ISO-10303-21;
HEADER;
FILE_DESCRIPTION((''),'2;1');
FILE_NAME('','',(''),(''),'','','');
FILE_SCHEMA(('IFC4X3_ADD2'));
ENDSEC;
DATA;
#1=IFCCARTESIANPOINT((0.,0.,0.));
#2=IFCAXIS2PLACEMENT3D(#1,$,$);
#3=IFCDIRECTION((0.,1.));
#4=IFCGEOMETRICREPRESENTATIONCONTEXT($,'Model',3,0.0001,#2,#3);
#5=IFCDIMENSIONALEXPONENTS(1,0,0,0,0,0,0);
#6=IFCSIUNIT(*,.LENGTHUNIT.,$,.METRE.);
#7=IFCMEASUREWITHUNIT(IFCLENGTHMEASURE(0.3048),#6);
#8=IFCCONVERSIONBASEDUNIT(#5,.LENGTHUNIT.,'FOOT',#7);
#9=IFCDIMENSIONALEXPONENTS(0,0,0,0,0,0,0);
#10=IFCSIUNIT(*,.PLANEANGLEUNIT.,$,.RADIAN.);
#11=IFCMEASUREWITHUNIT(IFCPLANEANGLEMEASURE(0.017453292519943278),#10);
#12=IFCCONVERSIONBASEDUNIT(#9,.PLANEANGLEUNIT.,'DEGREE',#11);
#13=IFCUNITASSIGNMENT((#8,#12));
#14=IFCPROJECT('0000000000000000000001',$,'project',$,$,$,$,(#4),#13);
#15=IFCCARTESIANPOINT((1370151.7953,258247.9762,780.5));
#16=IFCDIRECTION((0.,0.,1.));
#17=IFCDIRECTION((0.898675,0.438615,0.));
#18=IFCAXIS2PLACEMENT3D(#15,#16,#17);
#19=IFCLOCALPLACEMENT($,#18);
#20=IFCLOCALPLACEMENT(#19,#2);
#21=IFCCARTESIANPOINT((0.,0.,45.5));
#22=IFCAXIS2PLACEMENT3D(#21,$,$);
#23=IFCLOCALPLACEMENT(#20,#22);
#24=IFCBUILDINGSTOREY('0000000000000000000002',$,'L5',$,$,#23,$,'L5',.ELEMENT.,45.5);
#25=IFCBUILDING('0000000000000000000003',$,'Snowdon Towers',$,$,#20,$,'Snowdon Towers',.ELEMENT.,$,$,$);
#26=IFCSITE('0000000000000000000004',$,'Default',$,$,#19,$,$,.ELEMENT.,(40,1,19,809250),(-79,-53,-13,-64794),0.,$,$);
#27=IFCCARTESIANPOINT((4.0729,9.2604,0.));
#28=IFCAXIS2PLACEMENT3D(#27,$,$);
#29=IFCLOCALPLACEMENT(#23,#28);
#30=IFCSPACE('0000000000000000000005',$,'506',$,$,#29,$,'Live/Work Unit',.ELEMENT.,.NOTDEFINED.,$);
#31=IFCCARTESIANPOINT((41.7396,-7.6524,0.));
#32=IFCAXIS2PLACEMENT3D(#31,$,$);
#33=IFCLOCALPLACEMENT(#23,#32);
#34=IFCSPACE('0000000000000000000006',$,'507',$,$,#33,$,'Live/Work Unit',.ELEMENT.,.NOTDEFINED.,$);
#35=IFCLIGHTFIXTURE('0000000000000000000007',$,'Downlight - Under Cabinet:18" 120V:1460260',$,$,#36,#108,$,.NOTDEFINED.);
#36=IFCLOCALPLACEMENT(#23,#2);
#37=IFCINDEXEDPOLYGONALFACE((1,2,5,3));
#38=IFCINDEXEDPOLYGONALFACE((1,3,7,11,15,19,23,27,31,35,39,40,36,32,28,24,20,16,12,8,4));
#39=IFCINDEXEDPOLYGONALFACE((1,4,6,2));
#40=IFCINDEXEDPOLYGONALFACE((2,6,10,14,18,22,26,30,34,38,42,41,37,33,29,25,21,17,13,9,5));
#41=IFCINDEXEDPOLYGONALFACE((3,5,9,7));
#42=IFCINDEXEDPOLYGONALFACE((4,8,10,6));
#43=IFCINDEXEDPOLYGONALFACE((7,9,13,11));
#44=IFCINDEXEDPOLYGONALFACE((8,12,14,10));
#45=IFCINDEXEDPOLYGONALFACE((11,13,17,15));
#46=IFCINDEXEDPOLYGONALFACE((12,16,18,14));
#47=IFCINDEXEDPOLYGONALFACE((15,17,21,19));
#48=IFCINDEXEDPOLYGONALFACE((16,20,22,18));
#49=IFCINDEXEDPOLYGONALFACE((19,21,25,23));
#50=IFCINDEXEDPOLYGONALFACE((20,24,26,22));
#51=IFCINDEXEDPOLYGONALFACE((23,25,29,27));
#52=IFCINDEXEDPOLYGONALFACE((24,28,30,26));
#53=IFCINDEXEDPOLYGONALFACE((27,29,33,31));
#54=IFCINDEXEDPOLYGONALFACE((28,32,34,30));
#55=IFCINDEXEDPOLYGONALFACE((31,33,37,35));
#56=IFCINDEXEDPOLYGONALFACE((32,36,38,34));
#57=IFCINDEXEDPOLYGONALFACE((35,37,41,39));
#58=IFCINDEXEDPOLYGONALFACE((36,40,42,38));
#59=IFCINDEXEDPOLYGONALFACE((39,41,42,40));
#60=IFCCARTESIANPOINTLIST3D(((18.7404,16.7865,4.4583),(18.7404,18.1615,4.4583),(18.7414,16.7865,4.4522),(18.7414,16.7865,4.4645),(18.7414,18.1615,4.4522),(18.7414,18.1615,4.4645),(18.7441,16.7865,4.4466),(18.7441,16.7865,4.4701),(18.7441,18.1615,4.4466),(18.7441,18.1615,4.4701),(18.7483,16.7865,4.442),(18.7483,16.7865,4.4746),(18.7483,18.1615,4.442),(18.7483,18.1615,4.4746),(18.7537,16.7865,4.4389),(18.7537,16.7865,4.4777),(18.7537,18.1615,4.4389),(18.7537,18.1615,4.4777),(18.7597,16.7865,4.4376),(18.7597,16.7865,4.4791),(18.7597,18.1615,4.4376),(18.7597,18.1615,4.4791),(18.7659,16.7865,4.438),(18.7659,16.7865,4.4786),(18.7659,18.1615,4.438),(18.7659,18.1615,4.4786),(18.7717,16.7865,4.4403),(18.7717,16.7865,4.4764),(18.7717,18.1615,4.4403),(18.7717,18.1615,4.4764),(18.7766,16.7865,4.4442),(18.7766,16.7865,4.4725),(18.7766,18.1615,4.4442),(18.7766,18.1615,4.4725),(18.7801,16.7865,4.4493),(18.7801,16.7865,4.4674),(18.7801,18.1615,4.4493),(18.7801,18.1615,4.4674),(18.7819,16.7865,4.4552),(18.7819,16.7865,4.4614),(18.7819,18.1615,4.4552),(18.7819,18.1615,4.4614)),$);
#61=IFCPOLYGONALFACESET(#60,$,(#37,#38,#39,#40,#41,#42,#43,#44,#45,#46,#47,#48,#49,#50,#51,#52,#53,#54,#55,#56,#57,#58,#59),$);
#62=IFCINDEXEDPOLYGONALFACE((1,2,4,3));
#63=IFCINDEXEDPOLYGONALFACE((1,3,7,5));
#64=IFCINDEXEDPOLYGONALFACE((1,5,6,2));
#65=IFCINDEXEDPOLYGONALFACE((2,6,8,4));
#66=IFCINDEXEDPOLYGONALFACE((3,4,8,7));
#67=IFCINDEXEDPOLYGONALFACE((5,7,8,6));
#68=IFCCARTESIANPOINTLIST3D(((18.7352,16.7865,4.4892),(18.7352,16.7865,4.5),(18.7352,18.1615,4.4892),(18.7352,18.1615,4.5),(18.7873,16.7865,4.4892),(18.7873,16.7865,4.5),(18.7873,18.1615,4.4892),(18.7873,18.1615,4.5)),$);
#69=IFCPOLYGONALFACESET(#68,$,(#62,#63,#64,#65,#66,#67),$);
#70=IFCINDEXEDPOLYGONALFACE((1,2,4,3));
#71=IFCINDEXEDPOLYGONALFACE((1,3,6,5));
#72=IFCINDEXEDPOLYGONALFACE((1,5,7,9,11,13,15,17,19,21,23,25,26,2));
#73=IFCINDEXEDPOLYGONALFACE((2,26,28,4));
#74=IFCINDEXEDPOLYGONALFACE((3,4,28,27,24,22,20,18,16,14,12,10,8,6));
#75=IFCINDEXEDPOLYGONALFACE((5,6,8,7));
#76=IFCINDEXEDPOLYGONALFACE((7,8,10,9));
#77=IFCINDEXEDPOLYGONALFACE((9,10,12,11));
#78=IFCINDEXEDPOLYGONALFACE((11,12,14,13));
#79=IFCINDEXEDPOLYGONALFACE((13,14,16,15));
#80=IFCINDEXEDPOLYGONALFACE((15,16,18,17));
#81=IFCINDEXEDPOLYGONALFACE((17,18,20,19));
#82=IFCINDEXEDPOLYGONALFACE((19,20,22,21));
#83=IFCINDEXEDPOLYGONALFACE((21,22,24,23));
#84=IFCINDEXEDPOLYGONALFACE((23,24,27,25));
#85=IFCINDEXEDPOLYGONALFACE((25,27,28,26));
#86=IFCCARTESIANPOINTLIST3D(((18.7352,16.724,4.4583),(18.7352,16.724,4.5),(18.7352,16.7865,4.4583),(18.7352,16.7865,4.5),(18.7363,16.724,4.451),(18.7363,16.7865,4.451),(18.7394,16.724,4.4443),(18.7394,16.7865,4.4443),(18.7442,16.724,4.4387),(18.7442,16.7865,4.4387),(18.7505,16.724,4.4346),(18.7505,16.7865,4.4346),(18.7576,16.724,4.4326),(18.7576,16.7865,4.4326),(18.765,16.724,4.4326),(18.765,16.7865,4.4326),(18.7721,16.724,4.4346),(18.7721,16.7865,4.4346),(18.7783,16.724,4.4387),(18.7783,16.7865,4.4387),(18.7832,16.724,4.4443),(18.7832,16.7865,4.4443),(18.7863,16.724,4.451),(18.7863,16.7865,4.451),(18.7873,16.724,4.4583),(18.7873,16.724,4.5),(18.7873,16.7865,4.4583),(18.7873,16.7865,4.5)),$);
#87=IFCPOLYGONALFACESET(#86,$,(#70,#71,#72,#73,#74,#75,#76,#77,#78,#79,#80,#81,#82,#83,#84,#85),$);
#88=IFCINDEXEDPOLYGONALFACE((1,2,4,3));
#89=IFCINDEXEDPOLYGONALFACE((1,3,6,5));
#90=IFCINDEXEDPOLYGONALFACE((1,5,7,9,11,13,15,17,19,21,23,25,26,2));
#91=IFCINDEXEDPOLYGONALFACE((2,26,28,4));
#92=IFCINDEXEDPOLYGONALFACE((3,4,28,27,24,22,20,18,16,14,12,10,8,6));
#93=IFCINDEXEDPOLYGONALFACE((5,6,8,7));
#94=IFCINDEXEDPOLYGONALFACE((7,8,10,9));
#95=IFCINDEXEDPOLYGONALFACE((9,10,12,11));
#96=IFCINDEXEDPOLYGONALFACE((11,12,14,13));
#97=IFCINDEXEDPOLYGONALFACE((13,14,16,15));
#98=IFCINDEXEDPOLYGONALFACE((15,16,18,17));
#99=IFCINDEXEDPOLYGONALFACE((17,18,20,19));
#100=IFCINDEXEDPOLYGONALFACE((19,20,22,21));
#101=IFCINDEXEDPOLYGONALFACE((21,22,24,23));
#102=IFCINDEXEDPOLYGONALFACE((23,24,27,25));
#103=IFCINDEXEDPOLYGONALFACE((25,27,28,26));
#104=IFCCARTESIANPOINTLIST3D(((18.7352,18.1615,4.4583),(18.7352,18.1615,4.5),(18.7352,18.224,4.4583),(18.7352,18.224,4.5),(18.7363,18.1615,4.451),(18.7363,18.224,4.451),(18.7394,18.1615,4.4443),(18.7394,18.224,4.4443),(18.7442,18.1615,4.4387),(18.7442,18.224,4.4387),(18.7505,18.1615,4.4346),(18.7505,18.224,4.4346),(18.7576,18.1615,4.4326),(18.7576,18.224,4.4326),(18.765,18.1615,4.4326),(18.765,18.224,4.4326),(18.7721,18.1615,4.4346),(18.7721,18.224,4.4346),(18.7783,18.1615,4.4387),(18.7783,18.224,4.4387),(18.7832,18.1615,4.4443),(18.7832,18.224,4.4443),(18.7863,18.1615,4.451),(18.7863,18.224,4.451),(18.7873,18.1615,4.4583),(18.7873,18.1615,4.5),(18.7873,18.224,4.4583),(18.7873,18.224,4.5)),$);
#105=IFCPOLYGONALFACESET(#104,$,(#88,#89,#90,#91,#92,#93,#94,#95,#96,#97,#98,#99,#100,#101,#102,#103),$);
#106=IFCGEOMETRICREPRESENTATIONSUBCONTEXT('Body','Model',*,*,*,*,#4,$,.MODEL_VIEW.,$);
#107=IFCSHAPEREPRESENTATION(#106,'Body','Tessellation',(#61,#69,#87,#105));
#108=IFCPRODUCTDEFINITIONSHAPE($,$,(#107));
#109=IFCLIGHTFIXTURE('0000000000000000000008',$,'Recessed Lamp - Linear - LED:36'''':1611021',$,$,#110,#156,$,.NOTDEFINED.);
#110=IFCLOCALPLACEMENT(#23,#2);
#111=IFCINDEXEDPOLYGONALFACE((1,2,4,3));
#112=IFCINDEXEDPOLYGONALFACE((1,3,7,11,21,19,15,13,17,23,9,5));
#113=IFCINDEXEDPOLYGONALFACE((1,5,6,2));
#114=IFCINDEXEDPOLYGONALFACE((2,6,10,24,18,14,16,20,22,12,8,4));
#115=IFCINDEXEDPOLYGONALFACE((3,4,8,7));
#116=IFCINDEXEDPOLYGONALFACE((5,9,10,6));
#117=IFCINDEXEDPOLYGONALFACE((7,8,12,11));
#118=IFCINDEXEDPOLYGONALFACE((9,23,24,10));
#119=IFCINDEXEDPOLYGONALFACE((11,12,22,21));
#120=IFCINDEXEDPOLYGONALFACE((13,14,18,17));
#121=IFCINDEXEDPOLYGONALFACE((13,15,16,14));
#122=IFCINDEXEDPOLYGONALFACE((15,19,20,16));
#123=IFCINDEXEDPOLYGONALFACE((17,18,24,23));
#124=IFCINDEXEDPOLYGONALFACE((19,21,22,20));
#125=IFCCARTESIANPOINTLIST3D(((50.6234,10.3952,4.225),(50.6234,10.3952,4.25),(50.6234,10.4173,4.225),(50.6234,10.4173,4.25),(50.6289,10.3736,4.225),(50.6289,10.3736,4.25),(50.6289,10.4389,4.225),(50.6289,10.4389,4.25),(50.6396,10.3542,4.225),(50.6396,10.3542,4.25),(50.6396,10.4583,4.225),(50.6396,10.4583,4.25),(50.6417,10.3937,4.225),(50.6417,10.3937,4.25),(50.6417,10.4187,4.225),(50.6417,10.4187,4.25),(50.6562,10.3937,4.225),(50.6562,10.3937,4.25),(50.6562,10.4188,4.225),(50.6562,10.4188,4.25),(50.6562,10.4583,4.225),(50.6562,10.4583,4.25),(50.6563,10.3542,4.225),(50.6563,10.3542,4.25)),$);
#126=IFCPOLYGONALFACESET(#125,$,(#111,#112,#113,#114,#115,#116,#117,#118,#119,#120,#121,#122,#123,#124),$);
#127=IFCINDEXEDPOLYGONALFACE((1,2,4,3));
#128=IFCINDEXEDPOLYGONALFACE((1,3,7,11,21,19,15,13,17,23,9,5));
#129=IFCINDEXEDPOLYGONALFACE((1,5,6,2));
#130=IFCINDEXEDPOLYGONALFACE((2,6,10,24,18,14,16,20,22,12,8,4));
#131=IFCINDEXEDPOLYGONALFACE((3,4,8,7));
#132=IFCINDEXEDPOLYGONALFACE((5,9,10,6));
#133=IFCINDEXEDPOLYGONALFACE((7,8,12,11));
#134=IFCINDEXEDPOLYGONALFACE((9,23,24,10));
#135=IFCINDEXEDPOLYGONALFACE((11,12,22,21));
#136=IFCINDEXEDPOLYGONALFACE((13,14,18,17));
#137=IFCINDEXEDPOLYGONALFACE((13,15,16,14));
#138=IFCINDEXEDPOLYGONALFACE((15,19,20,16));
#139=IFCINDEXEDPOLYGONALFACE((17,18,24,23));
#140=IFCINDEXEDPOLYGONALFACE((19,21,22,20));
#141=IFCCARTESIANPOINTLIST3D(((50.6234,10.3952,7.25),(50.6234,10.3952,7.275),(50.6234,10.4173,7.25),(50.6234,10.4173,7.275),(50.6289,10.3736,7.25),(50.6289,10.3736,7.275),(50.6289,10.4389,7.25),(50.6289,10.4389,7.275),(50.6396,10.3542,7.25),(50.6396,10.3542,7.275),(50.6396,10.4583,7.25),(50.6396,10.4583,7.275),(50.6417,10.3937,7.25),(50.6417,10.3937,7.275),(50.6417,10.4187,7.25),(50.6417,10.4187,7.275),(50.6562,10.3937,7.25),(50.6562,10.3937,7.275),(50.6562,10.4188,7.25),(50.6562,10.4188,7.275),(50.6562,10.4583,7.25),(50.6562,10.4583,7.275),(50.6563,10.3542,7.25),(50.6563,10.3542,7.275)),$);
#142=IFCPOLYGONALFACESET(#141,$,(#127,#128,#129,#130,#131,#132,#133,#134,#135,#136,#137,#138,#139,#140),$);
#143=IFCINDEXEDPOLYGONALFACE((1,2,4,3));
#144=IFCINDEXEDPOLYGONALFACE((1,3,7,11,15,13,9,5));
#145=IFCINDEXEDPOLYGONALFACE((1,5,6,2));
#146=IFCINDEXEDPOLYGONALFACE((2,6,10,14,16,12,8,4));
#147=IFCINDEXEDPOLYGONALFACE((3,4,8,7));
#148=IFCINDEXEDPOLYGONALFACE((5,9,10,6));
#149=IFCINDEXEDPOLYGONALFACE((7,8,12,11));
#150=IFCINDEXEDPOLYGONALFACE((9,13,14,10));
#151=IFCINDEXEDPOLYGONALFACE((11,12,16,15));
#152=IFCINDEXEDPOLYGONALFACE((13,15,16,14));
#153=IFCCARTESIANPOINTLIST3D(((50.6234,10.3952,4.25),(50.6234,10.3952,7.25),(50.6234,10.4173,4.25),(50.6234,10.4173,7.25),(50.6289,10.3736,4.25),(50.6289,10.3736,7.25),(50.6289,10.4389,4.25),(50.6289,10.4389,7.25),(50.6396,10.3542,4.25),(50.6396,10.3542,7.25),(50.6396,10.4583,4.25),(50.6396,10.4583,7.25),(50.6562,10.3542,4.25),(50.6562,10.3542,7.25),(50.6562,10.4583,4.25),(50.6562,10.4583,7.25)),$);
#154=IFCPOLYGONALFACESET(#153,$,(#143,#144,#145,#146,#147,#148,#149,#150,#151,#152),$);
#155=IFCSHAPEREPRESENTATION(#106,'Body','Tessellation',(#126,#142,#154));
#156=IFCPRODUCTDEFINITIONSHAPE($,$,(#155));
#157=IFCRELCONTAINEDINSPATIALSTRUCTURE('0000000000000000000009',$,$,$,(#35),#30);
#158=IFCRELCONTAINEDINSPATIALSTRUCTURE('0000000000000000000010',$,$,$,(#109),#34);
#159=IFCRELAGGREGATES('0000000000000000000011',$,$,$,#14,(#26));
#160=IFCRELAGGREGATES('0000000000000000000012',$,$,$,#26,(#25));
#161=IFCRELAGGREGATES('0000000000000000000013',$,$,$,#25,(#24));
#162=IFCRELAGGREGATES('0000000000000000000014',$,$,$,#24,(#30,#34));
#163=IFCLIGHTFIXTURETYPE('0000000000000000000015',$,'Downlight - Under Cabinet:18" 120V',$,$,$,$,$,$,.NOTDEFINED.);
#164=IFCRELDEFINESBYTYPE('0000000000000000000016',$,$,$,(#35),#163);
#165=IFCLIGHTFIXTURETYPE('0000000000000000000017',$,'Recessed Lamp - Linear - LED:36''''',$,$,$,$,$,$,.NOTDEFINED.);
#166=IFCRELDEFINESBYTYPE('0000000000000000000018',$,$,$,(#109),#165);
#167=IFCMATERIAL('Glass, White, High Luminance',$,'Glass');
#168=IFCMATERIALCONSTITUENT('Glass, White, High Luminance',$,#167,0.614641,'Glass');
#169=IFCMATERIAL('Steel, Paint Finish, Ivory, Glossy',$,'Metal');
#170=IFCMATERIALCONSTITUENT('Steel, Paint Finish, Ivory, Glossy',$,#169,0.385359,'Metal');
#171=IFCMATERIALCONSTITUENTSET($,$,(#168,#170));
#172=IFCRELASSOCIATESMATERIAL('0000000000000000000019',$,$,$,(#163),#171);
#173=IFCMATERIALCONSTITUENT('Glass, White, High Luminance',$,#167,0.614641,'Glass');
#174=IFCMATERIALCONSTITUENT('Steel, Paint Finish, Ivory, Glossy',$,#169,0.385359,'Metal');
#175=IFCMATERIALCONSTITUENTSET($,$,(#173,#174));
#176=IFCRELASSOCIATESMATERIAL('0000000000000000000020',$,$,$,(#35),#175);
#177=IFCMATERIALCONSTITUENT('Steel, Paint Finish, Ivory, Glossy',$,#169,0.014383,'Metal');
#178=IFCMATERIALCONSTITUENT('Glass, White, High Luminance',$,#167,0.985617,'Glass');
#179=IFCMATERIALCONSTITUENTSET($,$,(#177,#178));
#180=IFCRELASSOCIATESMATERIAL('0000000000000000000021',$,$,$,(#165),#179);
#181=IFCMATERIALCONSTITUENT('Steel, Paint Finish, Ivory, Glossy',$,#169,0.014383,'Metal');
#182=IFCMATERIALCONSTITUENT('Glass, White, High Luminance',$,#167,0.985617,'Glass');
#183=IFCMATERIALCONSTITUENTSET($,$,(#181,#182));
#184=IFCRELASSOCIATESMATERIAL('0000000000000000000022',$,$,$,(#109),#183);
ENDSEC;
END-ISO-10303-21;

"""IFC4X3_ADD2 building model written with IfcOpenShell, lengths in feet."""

from ifc_helpers import new_model, entity, si_unit, converted_unit, direction, frame, frame_2d, origin, origin_2d_with_axis, place, context, subcontext, project, spatial, polyline, circle_curve, parameter, trimmed, segment, composite_curve, rectangle, circle, outline, extrude, source, transform, mapped, material, constituent, constituent_set, type_object, type_shapes, element, save


model = new_model("IFC4X3_ADD2")

# Units and contexts
model_context = context("Model", 3, precision=0.0001, world=origin(), true_north=direction((0.0, 1.0)))
body_context = subcontext(model_context, "Body", "Model", "MODEL_VIEW")
ifc_project = project(units=[converted_unit("LENGTHUNIT", "FOOT", entity("IfcLengthMeasure", 0.3048), si_unit("LENGTHUNIT", "METRE"), dimensions=[1, 0, 0, 0, 0, 0, 0]), converted_unit("PLANEANGLEUNIT", "DEGREE", entity("IfcPlaneAngleMeasure", 0.017453292519943278), si_unit("PLANEANGLEUNIT", "RADIAN"), dimensions=[0, 0, 0, 0, 0, 0, 0])], contexts=[model_context])

# Site, building, storey, space
site_placement = place(None, frame((1370151.7953, 258247.9762, 780.5), z_axis=(0.0, 0.0, 1.0), x_axis=(0.898675, 0.438615, 0.0)))
site = spatial("IfcSite", under=ifc_project, at=site_placement, Name="Default", CompositionType="ELEMENT", RefLatitude=(40, 1, 19, 809250), RefLongitude=(-79, -53, -13, -64794), RefElevation=0.0)
building_placement = place(site_placement, origin())
building = spatial("IfcBuilding", under=site, at=building_placement, Name="Snowdon Towers", LongName="Snowdon Towers", CompositionType="ELEMENT")
storey_placement = place(building_placement, frame((0.0, 0.0, 45.5)))
storey = spatial("IfcBuildingStorey", under=building, at=storey_placement, Name="L5", LongName="L5", CompositionType="ELEMENT", Elevation=45.5)
space_1_placement = place(storey_placement, frame((4.0729, 9.2604, 0.0)))
space_1 = spatial("IfcSpace", under=storey, at=space_1_placement, Name="506", LongName="Live/Work Unit", CompositionType="ELEMENT", PredefinedType="NOTDEFINED")

# Light fixture
ifc_material_1 = material(Name="Glass, White, High Luminance", Category="Glass")
ifc_constituent_1 = constituent(ifc_material_1, Name="Glass, White, High Luminance", Category="Glass", fraction=0.614641)
ifc_material_2 = material(Name="Steel, Paint Finish, Ivory, Glossy", Category="Metal")
ifc_constituent_2 = constituent(ifc_material_2, Name="Steel, Paint Finish, Ivory, Glossy", Category="Metal", fraction=0.385359)
ifc_constituent_set_1 = constituent_set(constituents=[ifc_constituent_1, ifc_constituent_2])
ifc_constituent_3 = constituent(ifc_material_1, Name="Glass, White, High Luminance", Category="Glass", fraction=0.614641)
ifc_constituent_4 = constituent(ifc_material_2, Name="Steel, Paint Finish, Ivory, Glossy", Category="Metal", fraction=0.385359)
ifc_constituent_set_2 = constituent_set(constituents=[ifc_constituent_3, ifc_constituent_4])
light_fixture_type_1 = type_object("IfcLightFixtureType", Name="Downlight - Under Cabinet:18\" 120V", PredefinedType="NOTDEFINED", material=ifc_constituent_set_2)
shared_shape_1 = source(origin(), body_context, "Body", "SweptSolid", [
    extrude(circle(Radius=0.0208, at=origin_2d_with_axis()), frame((-0.6875, 0.0, 4.4583), z_axis=(1.0, 0.0, 0.0), x_axis=(0.0, 1.0, 0.0)), (0.0, 0.0, 1.0), 1.375),
    extrude(rectangle(XDim=1.375, YDim=0.0521, at=origin_2d_with_axis()), frame((0.0, 0.0, 4.4892), z_axis=(0.0, 0.0, 1.0), x_axis=(-1.0, 0.0, 0.0)), (0.0, 0.0, 1.0), 0.0108),
    extrude(outline(composite_curve([segment(polyline([(-0.026, -0.0208), (0.026, -0.0208)]), True, "CONTINUOUS"), segment(polyline([(0.026, -0.0208), (0.026, 0.0208)]), True, "CONTINUOUS"), segment(trimmed(circle_curve(frame_2d((0.0, 0.0208), x_axis=(0.0, -1.0)), 0.026), [parameter(90.0)], [parameter(270.0)], True, "PARAMETER"), True, "CONTINUOUS"), segment(polyline([(-0.026, 0.0208), (-0.026, -0.0208)]), True, "CONTINUOUS")], self_intersect=False)), frame((-0.75, 0.0, 4.4792), z_axis=(1.0, 0.0, 0.0), x_axis=(0.0, -1.0, 0.0)), (0.0, 0.0, 1.0), 0.0625),
    extrude(outline(composite_curve([segment(polyline([(-0.0208, -0.026), (0.0208, -0.026)]), True, "CONTINUOUS"), segment(trimmed(circle_curve(frame_2d((0.0208, 0.0), x_axis=(0.0, 1.0)), 0.026), [parameter(180.0)], [parameter(360.0)], True, "PARAMETER"), True, "CONTINUOUS"), segment(polyline([(0.0208, 0.026), (-0.0208, 0.026)]), True, "CONTINUOUS"), segment(polyline([(-0.0208, 0.026), (-0.0208, -0.026)]), True, "CONTINUOUS")], self_intersect=False)), frame((0.6875, 0.0, 4.4792), z_axis=(1.0, 0.0, 0.0), x_axis=(0.0, 0.0, -1.0)), (0.0, 0.0, 1.0), 0.0625),
])
type_shapes(light_fixture_type_1, [shared_shape_1])
light_fixture_1_placement = place(space_1_placement, frame((14.6884, 8.2135, 0.0), z_axis=(0.0, 0.0, 1.0), x_axis=(0.0, 1.0, 0.0)))
element("IfcLightFixture", 1, at=light_fixture_1_placement, inside=space_1, type_object=light_fixture_type_1, material=ifc_constituent_set_1, Name="Downlight - Under Cabinet:18\" 120V:1460260", PredefinedType="NOTDEFINED", context=body_context, shape_type="MappedRepresentation", body=[
    mapped(shared_shape_1, transform((0.0, 0.0, 0.0), scale=1.0)),
])
ifc_constituent_5 = constituent(ifc_material_2, Name="Steel, Paint Finish, Ivory, Glossy", Category="Metal", fraction=0.014383)
ifc_constituent_6 = constituent(ifc_material_1, Name="Glass, White, High Luminance", Category="Glass", fraction=0.985617)
ifc_constituent_set_3 = constituent_set(constituents=[ifc_constituent_5, ifc_constituent_6])
light_fixture_type_2 = type_object("IfcLightFixtureType", Name="Recessed Lamp - Linear - LED:36''", PredefinedType="NOTDEFINED", material=ifc_constituent_set_3)
shared_shape_2 = source(origin(), body_context, "Body", "SweptSolid", [
    extrude(outline(composite_curve([segment(trimmed(circle_curve(frame_2d((0.0, -0.0633), x_axis=(1.0, 0.0)), 0.089), [parameter(54.196986)], [parameter(125.803014)], True, "PARAMETER"), True, "CONTINUOUS"), segment(polyline([(-0.0521, 0.0089), (-0.0521, -0.0078)]), True, "CONTINUOUS"), segment(polyline([(-0.0521, -0.0078), (-0.0125, -0.0078)]), True, "CONTINUOUS"), segment(polyline([(-0.0125, -0.0078), (-0.0125, 0.0068)]), True, "CONTINUOUS"), segment(polyline([(-0.0125, 0.0068), (0.0125, 0.0068)]), True, "CONTINUOUS"), segment(polyline([(0.0125, 0.0068), (0.0125, -0.0078)]), True, "CONTINUOUS"), segment(polyline([(0.0125, -0.0078), (0.0521, -0.0078)]), True, "CONTINUOUS"), segment(polyline([(0.0521, -0.0078), (0.0521, 0.0089)]), True, "CONTINUOUS")], self_intersect=False)), frame((-1.525, 0.0, 0.0078), z_axis=(1.0, 0.0, 0.0), x_axis=(0.0, 1.0, 0.0)), (0.0, 0.0, 1.0), 0.025),
    extrude(outline(composite_curve([segment(trimmed(circle_curve(frame_2d((0.0, -0.0633), x_axis=(1.0, 0.0)), 0.089), [parameter(54.196986)], [parameter(125.803014)], True, "PARAMETER"), True, "CONTINUOUS"), segment(polyline([(-0.0521, 0.0089), (-0.0521, -0.0078)]), True, "CONTINUOUS"), segment(polyline([(-0.0521, -0.0078), (-0.0125, -0.0078)]), True, "CONTINUOUS"), segment(polyline([(-0.0125, -0.0078), (-0.0125, 0.0068)]), True, "CONTINUOUS"), segment(polyline([(-0.0125, 0.0068), (0.0125, 0.0068)]), True, "CONTINUOUS"), segment(polyline([(0.0125, 0.0068), (0.0125, -0.0078)]), True, "CONTINUOUS"), segment(polyline([(0.0125, -0.0078), (0.0521, -0.0078)]), True, "CONTINUOUS"), segment(polyline([(0.0521, -0.0078), (0.0521, 0.0089)]), True, "CONTINUOUS")], self_intersect=False)), frame((1.5, 0.0, 0.0078), z_axis=(1.0, 0.0, 0.0), x_axis=(0.0, 1.0, 0.0)), (0.0, 0.0, 1.0), 0.025),
    extrude(outline(composite_curve([segment(trimmed(circle_curve(frame_2d((0.0, -0.0639), x_axis=(1.0, 0.0)), 0.089), [parameter(54.196986)], [parameter(125.803014)], True, "PARAMETER"), True, "CONTINUOUS"), segment(polyline([(-0.0521, 0.0083), (-0.0521, -0.0083)]), True, "CONTINUOUS"), segment(polyline([(-0.0521, -0.0083), (0.0521, -0.0083)]), True, "CONTINUOUS"), segment(polyline([(0.0521, -0.0083), (0.0521, 0.0083)]), True, "CONTINUOUS")], self_intersect=False)), frame((-1.5, 0.0, 0.0083), z_axis=(1.0, 0.0, 0.0), x_axis=(0.0, 1.0, 0.0)), (0.0, 0.0, 1.0), 3.0),
])
type_shapes(light_fixture_type_2, [shared_shape_2])

# Shared definitions
space_2_placement = place(storey_placement, frame((41.7396, -7.6524, 0.0)))
space_2 = spatial("IfcSpace", under=storey, at=space_2_placement, Name="507", LongName="Live/Work Unit", CompositionType="ELEMENT", PredefinedType="NOTDEFINED")

# Light fixture
ifc_constituent_7 = constituent(ifc_material_2, Name="Steel, Paint Finish, Ivory, Glossy", Category="Metal", fraction=0.014383)
ifc_constituent_8 = constituent(ifc_material_1, Name="Glass, White, High Luminance", Category="Glass", fraction=0.985617)
ifc_constituent_set_4 = constituent_set(constituents=[ifc_constituent_7, ifc_constituent_8])
light_fixture_2_placement = place(space_2_placement, frame((8.9167, 18.0586, 5.75), z_axis=(-1.0, 0.0, 0.0), x_axis=(0.0, 0.0, 1.0)))
element("IfcLightFixture", 2, at=light_fixture_2_placement, inside=space_2, type_object=light_fixture_type_2, material=ifc_constituent_set_4, Name="Recessed Lamp - Linear - LED:36'':1611021", PredefinedType="NOTDEFINED", context=body_context, shape_type="MappedRepresentation", body=[
    mapped(shared_shape_2, transform((0.0, 0.0, 0.0), scale=1.0)),
])

save(model, "model.ifc")
